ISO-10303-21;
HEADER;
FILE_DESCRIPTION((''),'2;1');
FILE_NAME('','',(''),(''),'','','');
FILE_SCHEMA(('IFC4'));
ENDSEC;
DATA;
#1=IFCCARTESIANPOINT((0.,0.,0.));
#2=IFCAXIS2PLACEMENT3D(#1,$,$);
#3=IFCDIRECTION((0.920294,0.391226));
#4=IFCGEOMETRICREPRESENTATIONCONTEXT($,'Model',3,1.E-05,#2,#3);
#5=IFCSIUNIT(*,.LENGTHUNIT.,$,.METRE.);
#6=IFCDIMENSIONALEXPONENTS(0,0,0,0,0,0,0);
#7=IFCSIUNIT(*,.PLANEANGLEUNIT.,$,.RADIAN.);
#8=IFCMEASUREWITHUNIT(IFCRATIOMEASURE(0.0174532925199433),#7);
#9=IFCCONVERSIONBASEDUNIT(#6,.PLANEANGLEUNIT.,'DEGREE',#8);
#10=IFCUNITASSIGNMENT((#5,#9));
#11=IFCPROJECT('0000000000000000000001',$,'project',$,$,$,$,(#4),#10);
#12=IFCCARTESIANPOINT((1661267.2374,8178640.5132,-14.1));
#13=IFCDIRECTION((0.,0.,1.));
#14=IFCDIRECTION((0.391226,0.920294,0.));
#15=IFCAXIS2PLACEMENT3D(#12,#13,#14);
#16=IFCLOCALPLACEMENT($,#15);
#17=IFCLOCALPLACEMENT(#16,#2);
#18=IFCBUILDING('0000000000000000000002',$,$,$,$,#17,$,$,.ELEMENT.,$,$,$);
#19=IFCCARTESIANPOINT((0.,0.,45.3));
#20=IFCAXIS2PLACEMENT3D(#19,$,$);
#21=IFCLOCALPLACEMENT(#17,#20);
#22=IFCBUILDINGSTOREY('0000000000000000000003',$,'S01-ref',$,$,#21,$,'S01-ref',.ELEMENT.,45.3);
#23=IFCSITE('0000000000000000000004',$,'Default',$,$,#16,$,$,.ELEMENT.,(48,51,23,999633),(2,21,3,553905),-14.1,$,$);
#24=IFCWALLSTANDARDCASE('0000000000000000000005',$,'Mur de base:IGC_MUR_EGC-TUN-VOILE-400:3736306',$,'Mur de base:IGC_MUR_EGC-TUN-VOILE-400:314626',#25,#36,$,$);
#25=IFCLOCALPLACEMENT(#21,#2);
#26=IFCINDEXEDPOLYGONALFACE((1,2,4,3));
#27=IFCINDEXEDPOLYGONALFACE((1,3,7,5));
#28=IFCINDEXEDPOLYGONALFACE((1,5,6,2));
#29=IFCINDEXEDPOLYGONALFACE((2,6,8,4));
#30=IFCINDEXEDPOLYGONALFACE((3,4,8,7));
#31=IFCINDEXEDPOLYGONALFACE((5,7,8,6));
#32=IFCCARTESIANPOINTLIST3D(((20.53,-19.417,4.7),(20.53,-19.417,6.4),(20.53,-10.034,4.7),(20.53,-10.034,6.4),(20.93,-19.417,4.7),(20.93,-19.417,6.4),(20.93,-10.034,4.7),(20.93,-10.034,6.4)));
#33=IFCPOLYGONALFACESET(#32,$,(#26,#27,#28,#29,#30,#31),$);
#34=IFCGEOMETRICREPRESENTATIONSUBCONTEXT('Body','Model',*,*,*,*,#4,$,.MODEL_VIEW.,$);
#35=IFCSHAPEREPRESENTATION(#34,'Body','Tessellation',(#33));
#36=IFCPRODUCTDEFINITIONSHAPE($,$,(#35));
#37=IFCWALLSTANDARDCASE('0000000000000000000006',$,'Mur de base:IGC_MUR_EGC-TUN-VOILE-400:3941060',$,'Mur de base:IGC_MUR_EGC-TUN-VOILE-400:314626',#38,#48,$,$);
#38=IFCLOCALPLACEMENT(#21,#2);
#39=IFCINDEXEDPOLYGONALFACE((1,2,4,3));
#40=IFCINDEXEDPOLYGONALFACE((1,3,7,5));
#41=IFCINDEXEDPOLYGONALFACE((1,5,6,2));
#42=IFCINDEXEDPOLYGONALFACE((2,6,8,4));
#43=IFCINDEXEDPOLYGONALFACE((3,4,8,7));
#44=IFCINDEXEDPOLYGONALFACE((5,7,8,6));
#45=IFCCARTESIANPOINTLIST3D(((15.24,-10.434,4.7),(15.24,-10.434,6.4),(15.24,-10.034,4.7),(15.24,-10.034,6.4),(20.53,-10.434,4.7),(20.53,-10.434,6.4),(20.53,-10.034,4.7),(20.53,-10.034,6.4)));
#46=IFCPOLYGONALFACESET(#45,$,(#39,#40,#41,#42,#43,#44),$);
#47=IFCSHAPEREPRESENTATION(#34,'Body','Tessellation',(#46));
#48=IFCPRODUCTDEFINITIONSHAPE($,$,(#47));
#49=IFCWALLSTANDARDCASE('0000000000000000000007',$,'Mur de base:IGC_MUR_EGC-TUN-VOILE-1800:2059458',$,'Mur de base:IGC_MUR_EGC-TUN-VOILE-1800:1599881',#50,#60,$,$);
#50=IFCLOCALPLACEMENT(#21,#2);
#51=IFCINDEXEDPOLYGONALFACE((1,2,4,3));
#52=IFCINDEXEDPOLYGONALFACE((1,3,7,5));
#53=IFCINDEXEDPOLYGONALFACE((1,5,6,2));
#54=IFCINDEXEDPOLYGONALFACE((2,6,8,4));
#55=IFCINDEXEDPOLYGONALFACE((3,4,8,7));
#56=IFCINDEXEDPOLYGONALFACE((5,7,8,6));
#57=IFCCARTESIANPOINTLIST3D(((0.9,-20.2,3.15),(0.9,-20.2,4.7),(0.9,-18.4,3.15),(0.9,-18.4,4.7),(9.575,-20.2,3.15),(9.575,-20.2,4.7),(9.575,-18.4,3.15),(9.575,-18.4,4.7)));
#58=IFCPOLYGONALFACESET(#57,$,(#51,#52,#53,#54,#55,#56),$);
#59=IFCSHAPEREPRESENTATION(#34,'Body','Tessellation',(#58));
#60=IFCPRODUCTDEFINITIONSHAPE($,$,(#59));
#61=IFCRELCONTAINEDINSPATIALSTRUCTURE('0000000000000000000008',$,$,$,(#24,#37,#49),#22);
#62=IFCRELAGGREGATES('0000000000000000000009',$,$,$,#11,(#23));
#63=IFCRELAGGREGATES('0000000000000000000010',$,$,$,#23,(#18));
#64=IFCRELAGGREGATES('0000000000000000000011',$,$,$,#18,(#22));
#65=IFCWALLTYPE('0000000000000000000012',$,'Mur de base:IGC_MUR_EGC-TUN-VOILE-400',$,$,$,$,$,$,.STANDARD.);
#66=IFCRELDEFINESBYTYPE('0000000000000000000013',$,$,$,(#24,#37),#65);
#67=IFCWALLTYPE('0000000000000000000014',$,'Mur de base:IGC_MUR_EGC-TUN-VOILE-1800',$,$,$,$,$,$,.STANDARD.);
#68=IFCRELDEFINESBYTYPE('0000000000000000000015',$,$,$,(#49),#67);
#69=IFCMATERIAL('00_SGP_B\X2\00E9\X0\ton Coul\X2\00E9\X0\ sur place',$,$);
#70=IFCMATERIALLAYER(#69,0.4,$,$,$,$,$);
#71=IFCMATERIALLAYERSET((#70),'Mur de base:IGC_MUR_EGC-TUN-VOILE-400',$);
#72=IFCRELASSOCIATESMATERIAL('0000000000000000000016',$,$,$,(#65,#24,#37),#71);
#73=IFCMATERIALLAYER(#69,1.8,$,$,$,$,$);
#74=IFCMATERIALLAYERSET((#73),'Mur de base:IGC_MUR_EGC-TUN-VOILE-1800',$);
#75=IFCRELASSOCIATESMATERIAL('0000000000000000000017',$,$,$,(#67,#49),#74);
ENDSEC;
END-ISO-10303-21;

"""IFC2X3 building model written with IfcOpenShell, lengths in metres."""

from ifc_helpers import new_model, entity, si_unit, converted_unit, direction, frame, frame_2d, origin, place, context, subcontext, project, spatial, rectangle, extrude, material, layer, layer_set, layer_usage, type_object, element, save


model = new_model("IFC2X3")

# Units and contexts
model_context = context("Model", 3, precision=1e-05, world=origin(), true_north=direction((0.920294, 0.391226)))
body_context = subcontext(model_context, "Body", "Model", "MODEL_VIEW")
ifc_project = project(units=[si_unit("LENGTHUNIT", "METRE"), converted_unit("PLANEANGLEUNIT", "DEGREE", entity("IfcRatioMeasure", 0.0174532925199433), si_unit("PLANEANGLEUNIT", "RADIAN"), dimensions=[0, 0, 0, 0, 0, 0, 0])], contexts=[model_context])

# Site, building, storey
site_placement = place(None, frame((1661267.2374, 8178640.5132, -14.1), z_axis=(0.0, 0.0, 1.0), x_axis=(0.391226, 0.920294, 0.0)))
site = spatial("IfcSite", under=ifc_project, at=site_placement, Name="Default", CompositionType="ELEMENT", RefLatitude=(48, 51, 23, 999633), RefLongitude=(2, 21, 3, 553905), RefElevation=-14.1)
building_placement = place(site_placement, origin())
building = spatial("IfcBuilding", under=site, at=building_placement, CompositionType="ELEMENT")
storey_placement = place(building_placement, frame((0.0, 0.0, 45.3)))
storey = spatial("IfcBuildingStorey", under=building, at=storey_placement, Name="S01-ref", LongName="S01-ref", CompositionType="ELEMENT", Elevation=45.3)

# Shared definitions
ifc_material = material(Name="00_SGP_Béton Coulé sur place")
ifc_layer_1 = layer(ifc_material, 0.4)
ifc_layer_set_1 = layer_set([ifc_layer_1], Name="Mur de base:IGC_MUR_EGC-TUN-VOILE-400")
wall_type_1 = type_object("IfcWallType", Name="Mur de base:IGC_MUR_EGC-TUN-VOILE-400", PredefinedType="STANDARD", material=ifc_layer_set_1)

# Walls
ifc_layer_usage_1 = layer_usage(ifc_layer_set_1, "AXIS2", "NEGATIVE", 0.2)
wall_1_placement = place(storey_placement, frame((20.73, -19.417, 4.7), z_axis=(0.0, 0.0, 1.0), x_axis=(0.0, 1.0, 0.0)))
element("IfcWallStandardCase", 1, at=wall_1_placement, inside=storey, type_object=wall_type_1, material=ifc_layer_usage_1, Name="Mur de base:IGC_MUR_EGC-TUN-VOILE-400:3736306", ObjectType="Mur de base:IGC_MUR_EGC-TUN-VOILE-400:314626", context=body_context, shape_type="SweptSolid", body=[
    extrude(rectangle(XDim=9.383, YDim=0.4, at=frame_2d((4.6915, 0.0), x_axis=(-1.0, 0.0))), origin(), (0.0, 0.0, 1.0), 1.7),
])
ifc_layer_usage_2 = layer_usage(ifc_layer_set_1, "AXIS2", "POSITIVE", -0.2)
wall_2_placement = place(storey_placement, frame((15.24, -10.234, 4.7)))
element("IfcWallStandardCase", 2, at=wall_2_placement, inside=storey, type_object=wall_type_1, material=ifc_layer_usage_2, Name="Mur de base:IGC_MUR_EGC-TUN-VOILE-400:3941060", ObjectType="Mur de base:IGC_MUR_EGC-TUN-VOILE-400:314626", context=body_context, shape_type="SweptSolid", body=[
    extrude(rectangle(XDim=5.29, YDim=0.4, at=frame_2d((2.645, 0.0), x_axis=(-1.0, 0.0))), origin(), (0.0, 0.0, 1.0), 1.7),
])
ifc_layer_2 = layer(ifc_material, 1.8)
ifc_layer_set_2 = layer_set([ifc_layer_2], Name="Mur de base:IGC_MUR_EGC-TUN-VOILE-1800")
ifc_layer_usage_3 = layer_usage(ifc_layer_set_2, "AXIS2", "NEGATIVE", 0.9)
wall_type_2 = type_object("IfcWallType", Name="Mur de base:IGC_MUR_EGC-TUN-VOILE-1800", PredefinedType="STANDARD", material=ifc_layer_set_2)
wall_3_placement = place(storey_placement, frame((9.575, -19.3, 3.15), z_axis=(0.0, 0.0, 1.0), x_axis=(-1.0, 0.0, 0.0)))
element("IfcWallStandardCase", 3, at=wall_3_placement, inside=storey, type_object=wall_type_2, material=ifc_layer_usage_3, Name="Mur de base:IGC_MUR_EGC-TUN-VOILE-1800:2059458", ObjectType="Mur de base:IGC_MUR_EGC-TUN-VOILE-1800:1599881", context=body_context, shape_type="SweptSolid", body=[
    extrude(rectangle(XDim=8.675, YDim=1.8, at=frame_2d((4.3375, 0.0), x_axis=(-1.0, 0.0))), origin(), (0.0, 0.0, 1.0), 1.55),
])

save(model, "model.ifc")
